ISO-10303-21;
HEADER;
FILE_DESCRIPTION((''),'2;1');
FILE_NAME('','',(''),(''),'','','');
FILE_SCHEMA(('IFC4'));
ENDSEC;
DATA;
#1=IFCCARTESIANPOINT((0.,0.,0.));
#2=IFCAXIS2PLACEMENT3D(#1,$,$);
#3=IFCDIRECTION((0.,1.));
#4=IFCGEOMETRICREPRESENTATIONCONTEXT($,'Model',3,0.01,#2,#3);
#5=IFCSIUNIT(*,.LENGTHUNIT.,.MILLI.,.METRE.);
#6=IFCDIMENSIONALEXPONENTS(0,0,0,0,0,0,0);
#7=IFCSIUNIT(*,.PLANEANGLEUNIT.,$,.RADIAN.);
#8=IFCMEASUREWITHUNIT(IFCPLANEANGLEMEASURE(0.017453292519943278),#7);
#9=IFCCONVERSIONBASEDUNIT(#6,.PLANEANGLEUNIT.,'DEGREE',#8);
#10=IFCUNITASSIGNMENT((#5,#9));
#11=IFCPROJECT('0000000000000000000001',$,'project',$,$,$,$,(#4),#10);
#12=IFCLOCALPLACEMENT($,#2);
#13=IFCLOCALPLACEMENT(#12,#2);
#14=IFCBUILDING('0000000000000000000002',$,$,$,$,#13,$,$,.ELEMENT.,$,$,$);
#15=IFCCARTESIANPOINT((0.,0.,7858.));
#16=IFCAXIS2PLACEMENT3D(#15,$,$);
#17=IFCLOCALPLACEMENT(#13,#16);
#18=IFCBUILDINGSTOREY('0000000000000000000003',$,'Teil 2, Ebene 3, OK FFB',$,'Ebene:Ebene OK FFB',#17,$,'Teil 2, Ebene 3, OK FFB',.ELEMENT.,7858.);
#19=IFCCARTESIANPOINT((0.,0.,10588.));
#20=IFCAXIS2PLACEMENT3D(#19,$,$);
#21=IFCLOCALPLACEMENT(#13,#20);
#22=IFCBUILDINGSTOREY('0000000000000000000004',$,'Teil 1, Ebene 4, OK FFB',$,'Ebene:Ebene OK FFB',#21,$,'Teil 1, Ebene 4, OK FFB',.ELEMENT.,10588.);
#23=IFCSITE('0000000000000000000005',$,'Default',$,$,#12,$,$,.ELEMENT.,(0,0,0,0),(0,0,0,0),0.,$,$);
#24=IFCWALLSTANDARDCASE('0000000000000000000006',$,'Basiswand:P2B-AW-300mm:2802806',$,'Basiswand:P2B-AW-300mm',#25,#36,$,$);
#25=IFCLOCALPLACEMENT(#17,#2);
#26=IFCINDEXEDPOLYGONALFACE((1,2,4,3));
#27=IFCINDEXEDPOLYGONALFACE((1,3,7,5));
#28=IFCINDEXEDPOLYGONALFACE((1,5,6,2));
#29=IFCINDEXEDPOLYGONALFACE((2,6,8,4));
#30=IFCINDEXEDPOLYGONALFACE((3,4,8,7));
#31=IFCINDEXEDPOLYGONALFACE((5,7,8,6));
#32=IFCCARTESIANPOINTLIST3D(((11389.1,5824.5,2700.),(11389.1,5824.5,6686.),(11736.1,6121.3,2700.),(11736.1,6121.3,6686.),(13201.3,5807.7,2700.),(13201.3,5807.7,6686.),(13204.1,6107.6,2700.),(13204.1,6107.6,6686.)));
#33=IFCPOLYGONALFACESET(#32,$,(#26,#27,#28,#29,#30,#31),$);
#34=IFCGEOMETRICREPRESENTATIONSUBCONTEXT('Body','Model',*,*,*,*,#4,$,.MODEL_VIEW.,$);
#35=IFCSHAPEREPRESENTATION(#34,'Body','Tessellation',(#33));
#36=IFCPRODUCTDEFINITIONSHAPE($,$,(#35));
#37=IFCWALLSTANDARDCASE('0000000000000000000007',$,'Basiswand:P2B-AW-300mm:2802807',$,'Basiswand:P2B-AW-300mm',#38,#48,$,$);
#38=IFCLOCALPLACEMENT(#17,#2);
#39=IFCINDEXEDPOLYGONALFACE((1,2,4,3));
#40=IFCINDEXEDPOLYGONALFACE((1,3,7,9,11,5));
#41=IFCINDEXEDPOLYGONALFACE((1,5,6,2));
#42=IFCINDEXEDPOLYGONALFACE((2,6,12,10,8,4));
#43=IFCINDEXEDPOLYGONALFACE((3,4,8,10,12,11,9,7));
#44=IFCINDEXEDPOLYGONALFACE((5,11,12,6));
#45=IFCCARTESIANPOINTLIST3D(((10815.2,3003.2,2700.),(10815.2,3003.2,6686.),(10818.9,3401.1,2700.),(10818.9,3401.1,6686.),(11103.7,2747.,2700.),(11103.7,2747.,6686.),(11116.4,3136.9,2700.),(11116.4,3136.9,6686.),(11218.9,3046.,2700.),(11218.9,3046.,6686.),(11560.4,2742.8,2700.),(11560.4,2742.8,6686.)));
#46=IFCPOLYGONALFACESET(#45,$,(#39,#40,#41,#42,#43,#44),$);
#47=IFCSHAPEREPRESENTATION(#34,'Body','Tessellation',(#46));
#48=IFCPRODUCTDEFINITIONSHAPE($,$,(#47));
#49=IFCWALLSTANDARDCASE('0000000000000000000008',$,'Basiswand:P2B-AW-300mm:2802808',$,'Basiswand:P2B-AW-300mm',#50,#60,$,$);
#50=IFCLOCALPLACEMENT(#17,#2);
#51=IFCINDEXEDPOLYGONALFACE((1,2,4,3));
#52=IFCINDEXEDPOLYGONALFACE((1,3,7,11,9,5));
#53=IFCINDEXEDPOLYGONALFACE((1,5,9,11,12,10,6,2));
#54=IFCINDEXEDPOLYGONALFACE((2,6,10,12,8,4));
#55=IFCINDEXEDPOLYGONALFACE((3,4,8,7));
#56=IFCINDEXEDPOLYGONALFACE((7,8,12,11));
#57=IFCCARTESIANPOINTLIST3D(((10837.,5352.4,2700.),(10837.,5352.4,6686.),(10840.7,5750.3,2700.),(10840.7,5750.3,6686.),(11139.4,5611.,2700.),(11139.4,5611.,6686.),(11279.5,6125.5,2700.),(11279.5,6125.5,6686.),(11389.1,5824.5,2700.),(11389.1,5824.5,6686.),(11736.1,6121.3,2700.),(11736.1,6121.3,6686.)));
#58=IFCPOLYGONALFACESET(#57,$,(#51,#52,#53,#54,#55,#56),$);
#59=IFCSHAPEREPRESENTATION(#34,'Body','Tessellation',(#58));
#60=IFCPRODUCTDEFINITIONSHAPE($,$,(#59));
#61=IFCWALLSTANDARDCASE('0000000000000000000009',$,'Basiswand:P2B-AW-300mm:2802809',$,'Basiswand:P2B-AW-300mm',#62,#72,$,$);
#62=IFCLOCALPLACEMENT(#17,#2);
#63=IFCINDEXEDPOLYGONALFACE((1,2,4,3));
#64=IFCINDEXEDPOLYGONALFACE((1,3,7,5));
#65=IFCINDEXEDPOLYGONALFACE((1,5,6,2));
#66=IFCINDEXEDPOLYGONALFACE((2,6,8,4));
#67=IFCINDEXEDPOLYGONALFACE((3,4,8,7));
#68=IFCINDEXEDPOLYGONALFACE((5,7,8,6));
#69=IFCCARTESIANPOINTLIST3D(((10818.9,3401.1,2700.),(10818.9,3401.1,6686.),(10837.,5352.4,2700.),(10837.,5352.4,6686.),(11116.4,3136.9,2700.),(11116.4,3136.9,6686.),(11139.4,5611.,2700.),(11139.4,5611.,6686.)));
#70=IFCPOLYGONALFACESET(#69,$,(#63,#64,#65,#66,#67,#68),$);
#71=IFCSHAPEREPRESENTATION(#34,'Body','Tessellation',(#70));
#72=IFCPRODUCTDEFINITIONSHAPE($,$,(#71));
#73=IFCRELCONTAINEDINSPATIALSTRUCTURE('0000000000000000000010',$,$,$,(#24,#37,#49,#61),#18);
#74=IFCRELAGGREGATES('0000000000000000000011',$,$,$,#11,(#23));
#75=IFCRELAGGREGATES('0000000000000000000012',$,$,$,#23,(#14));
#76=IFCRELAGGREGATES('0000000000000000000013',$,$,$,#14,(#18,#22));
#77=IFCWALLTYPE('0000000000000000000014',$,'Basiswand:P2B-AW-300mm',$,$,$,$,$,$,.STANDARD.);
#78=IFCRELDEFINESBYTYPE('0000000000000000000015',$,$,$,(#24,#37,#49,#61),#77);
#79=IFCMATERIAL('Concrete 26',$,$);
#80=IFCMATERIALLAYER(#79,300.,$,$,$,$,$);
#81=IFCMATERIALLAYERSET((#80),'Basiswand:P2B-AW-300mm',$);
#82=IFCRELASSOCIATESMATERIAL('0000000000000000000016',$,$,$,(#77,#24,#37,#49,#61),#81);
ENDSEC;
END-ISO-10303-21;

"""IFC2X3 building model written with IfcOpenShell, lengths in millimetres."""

from ifc_helpers import new_model, entity, si_unit, converted_unit, direction, frame, origin, place, context, subcontext, project, spatial, polyline, outline, extrude, material, layer, layer_set, layer_usage, type_object, element, save


model = new_model("IFC2X3")

# Units and contexts
model_context = context("Model", 3, precision=0.01, world=origin(), true_north=direction((0.0, 1.0)))
body_context = subcontext(model_context, "Body", "Model", "MODEL_VIEW")
ifc_project = project(units=[si_unit("LENGTHUNIT", "METRE", prefix="MILLI"), converted_unit("PLANEANGLEUNIT", "DEGREE", entity("IfcPlaneAngleMeasure", 0.017453292519943278), si_unit("PLANEANGLEUNIT", "RADIAN"), dimensions=[0, 0, 0, 0, 0, 0, 0])], contexts=[model_context])

# Site, building, storey
site_placement = place(None, origin())
site = spatial("IfcSite", under=ifc_project, at=site_placement, Name="Default", CompositionType="ELEMENT", RefLatitude=(0, 0, 0, 0), RefLongitude=(0, 0, 0, 0), RefElevation=0.0)
building_placement = place(site_placement, origin())
building = spatial("IfcBuilding", under=site, at=building_placement, CompositionType="ELEMENT")
storey_1_placement = place(building_placement, frame((0.0, 0.0, 7858.0)))
storey_1 = spatial("IfcBuildingStorey", under=building, at=storey_1_placement, Name="Teil 2, Ebene 3, OK FFB", ObjectType="Ebene:Ebene OK FFB", LongName="Teil 2, Ebene 3, OK FFB", CompositionType="ELEMENT", Elevation=7858.0)

# Shared definitions
storey_2_placement = place(building_placement, frame((0.0, 0.0, 10588.0)))
storey_2 = spatial("IfcBuildingStorey", under=building, at=storey_2_placement, Name="Teil 1, Ebene 4, OK FFB", ObjectType="Ebene:Ebene OK FFB", LongName="Teil 1, Ebene 4, OK FFB", CompositionType="ELEMENT", Elevation=10588.0)

# Walls
ifc_material_1 = material(Name="Concrete 26")
ifc_layer_1 = layer(ifc_material_1, 300.0)
ifc_layer_set_1 = layer_set([ifc_layer_1], Name="Basiswand:P2B-AW-300mm")
wall_type_1 = type_object("IfcWallType", Name="Basiswand:P2B-AW-300mm", PredefinedType="STANDARD", material=ifc_layer_set_1)
ifc_layer_usage_1 = layer_usage(ifc_layer_set_1, "AXIS2", "POSITIVE", -150.0)
wall_1_placement = place(storey_1_placement, frame((13202.7, 5957.6, 2700.0), z_axis=(0.0, 0.0, 1.0), x_axis=(-0.999957, 0.009291, 0.0)))
element("IfcWallStandardCase", 1, at=wall_1_placement, inside=storey_1, type_object=wall_type_1, material=ifc_layer_usage_1, Name="Basiswand:P2B-AW-300mm:2802806", ObjectType="Basiswand:P2B-AW-300mm", context=body_context, shape_type="SweptSolid", body=[
    extrude(outline(polyline([(1468.0, -150.0), (1812.3, 150.0), (0.0, 150.0), (0.0, -150.0), (1468.0, -150.0)])), origin(), (0.0, 0.0, 1.0), 3986.0),
])
ifc_layer_usage_2 = layer_usage(ifc_layer_set_1, "AXIS2", "NEGATIVE", 150.0)
wall_2_placement = place(storey_1_placement, frame((11460.8, 2630.6, 2700.0), z_axis=(0.0, 0.0, 1.0), x_axis=(-0.747807, 0.663916, 0.0)))
element("IfcWallStandardCase", 2, at=wall_2_placement, inside=storey_1, type_object=wall_type_1, material=ifc_layer_usage_2, Name="Basiswand:P2B-AW-300mm:2802807", ObjectType="Basiswand:P2B-AW-300mm", context=body_context, shape_type="SweptSolid", body=[
    extrude(outline(polyline([(991.6, -150.0), (730.2, 150.0), (344.3, 150.0), (0.0, -150.0), (456.7, -150.0), (593.7, -150.0), (991.6, -150.0)])), origin(), (0.0, 0.0, 1.0), 3986.0),
])
ifc_layer_usage_3 = layer_usage(ifc_layer_set_1, "AXIS2", "POSITIVE", -150.0)
wall_3_placement = place(storey_1_placement, frame((11638.7, 6235.3, 2700.0), z_axis=(0.0, 0.0, 1.0), x_axis=(-0.760013, -0.649908, 0.0)))
element("IfcWallStandardCase", 3, at=wall_3_placement, inside=storey_1, type_object=wall_type_1, material=ifc_layer_usage_3, Name="Basiswand:P2B-AW-300mm:2802808", ObjectType="Basiswand:P2B-AW-300mm", context=body_context, shape_type="SweptSolid", body=[
    extrude(outline(polyline([(921.6, -150.0), (1183.1, 150.0), (785.1, 150.0), (456.7, 150.0), (0.0, 150.0), (344.3, -150.0), (921.6, -150.0)])), origin(), (0.0, 0.0, 1.0), 3986.0),
])
ifc_layer_usage_4 = layer_usage(ifc_layer_set_1, "AXIS2", "NEGATIVE", 150.0)
wall_4_placement = place(storey_1_placement, frame((10966.4, 3138.3, 2700.0), z_axis=(0.0, 0.0, 1.0), x_axis=(0.009291, 0.999957, 0.0)))
element("IfcWallStandardCase", 4, at=wall_4_placement, inside=storey_1, type_object=wall_type_1, material=ifc_layer_usage_4, Name="Basiswand:P2B-AW-300mm:2802809", ObjectType="Basiswand:P2B-AW-300mm", context=body_context, shape_type="SweptSolid", body=[
    extrude(outline(polyline([(2474.2, -150.0), (2212.8, 150.0), (261.4, 150.0), (0.0, -150.0), (2474.2, -150.0)])), origin(), (0.0, 0.0, 1.0), 3986.0),
])

save(model, "model.ifc")
